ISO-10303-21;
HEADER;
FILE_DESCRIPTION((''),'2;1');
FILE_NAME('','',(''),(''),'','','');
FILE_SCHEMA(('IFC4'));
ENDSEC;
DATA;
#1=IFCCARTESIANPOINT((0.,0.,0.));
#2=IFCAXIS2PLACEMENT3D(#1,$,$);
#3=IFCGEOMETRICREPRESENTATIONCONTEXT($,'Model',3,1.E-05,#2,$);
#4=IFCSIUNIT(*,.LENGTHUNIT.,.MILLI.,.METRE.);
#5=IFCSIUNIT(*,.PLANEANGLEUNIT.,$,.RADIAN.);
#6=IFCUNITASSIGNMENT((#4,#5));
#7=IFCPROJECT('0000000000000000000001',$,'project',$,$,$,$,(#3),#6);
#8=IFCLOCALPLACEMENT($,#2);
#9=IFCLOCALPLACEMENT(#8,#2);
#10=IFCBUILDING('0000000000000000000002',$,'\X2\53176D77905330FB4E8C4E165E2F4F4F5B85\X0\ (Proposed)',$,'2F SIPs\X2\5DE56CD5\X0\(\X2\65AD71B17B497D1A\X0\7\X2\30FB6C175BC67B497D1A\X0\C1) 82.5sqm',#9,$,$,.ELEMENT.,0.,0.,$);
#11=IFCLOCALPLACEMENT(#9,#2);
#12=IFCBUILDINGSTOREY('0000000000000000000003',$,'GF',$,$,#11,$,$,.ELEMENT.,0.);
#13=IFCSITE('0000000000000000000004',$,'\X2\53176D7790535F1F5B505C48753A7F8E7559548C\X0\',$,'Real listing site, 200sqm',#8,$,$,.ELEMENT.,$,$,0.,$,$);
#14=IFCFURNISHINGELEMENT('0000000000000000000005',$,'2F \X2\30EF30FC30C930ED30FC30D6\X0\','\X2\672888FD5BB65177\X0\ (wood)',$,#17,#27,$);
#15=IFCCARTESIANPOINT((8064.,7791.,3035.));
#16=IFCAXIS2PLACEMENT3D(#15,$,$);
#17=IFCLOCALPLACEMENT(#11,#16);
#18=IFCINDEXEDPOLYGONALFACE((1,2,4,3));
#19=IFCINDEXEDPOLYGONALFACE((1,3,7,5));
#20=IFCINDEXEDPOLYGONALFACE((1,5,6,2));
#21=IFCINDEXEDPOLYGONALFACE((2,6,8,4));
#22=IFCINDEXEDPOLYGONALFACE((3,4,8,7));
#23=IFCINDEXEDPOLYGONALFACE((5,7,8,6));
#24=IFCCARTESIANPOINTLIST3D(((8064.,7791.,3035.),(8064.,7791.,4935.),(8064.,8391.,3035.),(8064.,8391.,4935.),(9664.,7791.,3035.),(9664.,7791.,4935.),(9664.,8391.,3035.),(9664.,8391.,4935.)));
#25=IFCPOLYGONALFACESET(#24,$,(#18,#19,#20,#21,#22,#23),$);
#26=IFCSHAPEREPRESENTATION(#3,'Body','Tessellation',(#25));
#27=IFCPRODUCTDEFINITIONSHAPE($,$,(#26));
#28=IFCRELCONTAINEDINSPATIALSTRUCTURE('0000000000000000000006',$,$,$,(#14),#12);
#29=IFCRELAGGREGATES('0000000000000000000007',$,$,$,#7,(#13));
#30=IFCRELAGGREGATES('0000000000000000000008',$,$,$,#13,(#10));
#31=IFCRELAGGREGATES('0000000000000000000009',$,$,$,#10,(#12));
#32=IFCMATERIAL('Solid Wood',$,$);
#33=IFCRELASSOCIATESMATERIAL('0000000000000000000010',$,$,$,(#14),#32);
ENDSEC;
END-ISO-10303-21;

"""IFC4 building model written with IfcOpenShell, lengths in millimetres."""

from ifc_helpers import new_model, si_unit, frame, frame_2d, origin, place, context, project, spatial, rectangle, extrude, material, element, save


model = new_model("IFC4")

# Units and contexts
model_context = context("Model", 3, precision=1e-05, world=origin())
ifc_project = project(units=[si_unit("LENGTHUNIT", "METRE", prefix="MILLI"), si_unit("PLANEANGLEUNIT", "RADIAN")], contexts=[model_context])

# Site, building, storey
site_placement = place(None, origin())
site = spatial("IfcSite", under=ifc_project, at=site_placement, Name="北海道弟子屈町美留和", ObjectType="Real listing site, 200sqm", CompositionType="ELEMENT", RefElevation=0.0)
building_placement = place(site_placement, origin())
building = spatial("IfcBuilding", under=site, at=building_placement, Name="北海道・二世帯住宅 (Proposed)", ObjectType="2F SIPs工法(断熱等級7・気密等級C1) 82.5sqm", CompositionType="ELEMENT", ElevationOfRefHeight=0.0, ElevationOfTerrain=0.0)
storey_placement = place(building_placement, origin())
storey = spatial("IfcBuildingStorey", under=building, at=storey_placement, Name="GF", CompositionType="ELEMENT", Elevation=0.0)

# Shared definitions
ifc_material_1 = material(Name="Solid Wood")

# Furnishing element
furnishing_placement = place(storey_placement, frame((8064.0, 7791.0, 3035.0)))
element("IfcFurnishingElement", 1, at=furnishing_placement, inside=storey, material=ifc_material_1, Name="2F ワードローブ", Description="木製家具 (wood)", context=model_context, shape_type="SweptSolid", body=[
    extrude(rectangle(XDim=1600.0, YDim=600.0, at=frame_2d((800.0, 300.0))), frame((8064.0, 7791.0, 3035.0)), (0.0, 0.0, 1.0), 1900.0),
])

save(model, "model.ifc")
